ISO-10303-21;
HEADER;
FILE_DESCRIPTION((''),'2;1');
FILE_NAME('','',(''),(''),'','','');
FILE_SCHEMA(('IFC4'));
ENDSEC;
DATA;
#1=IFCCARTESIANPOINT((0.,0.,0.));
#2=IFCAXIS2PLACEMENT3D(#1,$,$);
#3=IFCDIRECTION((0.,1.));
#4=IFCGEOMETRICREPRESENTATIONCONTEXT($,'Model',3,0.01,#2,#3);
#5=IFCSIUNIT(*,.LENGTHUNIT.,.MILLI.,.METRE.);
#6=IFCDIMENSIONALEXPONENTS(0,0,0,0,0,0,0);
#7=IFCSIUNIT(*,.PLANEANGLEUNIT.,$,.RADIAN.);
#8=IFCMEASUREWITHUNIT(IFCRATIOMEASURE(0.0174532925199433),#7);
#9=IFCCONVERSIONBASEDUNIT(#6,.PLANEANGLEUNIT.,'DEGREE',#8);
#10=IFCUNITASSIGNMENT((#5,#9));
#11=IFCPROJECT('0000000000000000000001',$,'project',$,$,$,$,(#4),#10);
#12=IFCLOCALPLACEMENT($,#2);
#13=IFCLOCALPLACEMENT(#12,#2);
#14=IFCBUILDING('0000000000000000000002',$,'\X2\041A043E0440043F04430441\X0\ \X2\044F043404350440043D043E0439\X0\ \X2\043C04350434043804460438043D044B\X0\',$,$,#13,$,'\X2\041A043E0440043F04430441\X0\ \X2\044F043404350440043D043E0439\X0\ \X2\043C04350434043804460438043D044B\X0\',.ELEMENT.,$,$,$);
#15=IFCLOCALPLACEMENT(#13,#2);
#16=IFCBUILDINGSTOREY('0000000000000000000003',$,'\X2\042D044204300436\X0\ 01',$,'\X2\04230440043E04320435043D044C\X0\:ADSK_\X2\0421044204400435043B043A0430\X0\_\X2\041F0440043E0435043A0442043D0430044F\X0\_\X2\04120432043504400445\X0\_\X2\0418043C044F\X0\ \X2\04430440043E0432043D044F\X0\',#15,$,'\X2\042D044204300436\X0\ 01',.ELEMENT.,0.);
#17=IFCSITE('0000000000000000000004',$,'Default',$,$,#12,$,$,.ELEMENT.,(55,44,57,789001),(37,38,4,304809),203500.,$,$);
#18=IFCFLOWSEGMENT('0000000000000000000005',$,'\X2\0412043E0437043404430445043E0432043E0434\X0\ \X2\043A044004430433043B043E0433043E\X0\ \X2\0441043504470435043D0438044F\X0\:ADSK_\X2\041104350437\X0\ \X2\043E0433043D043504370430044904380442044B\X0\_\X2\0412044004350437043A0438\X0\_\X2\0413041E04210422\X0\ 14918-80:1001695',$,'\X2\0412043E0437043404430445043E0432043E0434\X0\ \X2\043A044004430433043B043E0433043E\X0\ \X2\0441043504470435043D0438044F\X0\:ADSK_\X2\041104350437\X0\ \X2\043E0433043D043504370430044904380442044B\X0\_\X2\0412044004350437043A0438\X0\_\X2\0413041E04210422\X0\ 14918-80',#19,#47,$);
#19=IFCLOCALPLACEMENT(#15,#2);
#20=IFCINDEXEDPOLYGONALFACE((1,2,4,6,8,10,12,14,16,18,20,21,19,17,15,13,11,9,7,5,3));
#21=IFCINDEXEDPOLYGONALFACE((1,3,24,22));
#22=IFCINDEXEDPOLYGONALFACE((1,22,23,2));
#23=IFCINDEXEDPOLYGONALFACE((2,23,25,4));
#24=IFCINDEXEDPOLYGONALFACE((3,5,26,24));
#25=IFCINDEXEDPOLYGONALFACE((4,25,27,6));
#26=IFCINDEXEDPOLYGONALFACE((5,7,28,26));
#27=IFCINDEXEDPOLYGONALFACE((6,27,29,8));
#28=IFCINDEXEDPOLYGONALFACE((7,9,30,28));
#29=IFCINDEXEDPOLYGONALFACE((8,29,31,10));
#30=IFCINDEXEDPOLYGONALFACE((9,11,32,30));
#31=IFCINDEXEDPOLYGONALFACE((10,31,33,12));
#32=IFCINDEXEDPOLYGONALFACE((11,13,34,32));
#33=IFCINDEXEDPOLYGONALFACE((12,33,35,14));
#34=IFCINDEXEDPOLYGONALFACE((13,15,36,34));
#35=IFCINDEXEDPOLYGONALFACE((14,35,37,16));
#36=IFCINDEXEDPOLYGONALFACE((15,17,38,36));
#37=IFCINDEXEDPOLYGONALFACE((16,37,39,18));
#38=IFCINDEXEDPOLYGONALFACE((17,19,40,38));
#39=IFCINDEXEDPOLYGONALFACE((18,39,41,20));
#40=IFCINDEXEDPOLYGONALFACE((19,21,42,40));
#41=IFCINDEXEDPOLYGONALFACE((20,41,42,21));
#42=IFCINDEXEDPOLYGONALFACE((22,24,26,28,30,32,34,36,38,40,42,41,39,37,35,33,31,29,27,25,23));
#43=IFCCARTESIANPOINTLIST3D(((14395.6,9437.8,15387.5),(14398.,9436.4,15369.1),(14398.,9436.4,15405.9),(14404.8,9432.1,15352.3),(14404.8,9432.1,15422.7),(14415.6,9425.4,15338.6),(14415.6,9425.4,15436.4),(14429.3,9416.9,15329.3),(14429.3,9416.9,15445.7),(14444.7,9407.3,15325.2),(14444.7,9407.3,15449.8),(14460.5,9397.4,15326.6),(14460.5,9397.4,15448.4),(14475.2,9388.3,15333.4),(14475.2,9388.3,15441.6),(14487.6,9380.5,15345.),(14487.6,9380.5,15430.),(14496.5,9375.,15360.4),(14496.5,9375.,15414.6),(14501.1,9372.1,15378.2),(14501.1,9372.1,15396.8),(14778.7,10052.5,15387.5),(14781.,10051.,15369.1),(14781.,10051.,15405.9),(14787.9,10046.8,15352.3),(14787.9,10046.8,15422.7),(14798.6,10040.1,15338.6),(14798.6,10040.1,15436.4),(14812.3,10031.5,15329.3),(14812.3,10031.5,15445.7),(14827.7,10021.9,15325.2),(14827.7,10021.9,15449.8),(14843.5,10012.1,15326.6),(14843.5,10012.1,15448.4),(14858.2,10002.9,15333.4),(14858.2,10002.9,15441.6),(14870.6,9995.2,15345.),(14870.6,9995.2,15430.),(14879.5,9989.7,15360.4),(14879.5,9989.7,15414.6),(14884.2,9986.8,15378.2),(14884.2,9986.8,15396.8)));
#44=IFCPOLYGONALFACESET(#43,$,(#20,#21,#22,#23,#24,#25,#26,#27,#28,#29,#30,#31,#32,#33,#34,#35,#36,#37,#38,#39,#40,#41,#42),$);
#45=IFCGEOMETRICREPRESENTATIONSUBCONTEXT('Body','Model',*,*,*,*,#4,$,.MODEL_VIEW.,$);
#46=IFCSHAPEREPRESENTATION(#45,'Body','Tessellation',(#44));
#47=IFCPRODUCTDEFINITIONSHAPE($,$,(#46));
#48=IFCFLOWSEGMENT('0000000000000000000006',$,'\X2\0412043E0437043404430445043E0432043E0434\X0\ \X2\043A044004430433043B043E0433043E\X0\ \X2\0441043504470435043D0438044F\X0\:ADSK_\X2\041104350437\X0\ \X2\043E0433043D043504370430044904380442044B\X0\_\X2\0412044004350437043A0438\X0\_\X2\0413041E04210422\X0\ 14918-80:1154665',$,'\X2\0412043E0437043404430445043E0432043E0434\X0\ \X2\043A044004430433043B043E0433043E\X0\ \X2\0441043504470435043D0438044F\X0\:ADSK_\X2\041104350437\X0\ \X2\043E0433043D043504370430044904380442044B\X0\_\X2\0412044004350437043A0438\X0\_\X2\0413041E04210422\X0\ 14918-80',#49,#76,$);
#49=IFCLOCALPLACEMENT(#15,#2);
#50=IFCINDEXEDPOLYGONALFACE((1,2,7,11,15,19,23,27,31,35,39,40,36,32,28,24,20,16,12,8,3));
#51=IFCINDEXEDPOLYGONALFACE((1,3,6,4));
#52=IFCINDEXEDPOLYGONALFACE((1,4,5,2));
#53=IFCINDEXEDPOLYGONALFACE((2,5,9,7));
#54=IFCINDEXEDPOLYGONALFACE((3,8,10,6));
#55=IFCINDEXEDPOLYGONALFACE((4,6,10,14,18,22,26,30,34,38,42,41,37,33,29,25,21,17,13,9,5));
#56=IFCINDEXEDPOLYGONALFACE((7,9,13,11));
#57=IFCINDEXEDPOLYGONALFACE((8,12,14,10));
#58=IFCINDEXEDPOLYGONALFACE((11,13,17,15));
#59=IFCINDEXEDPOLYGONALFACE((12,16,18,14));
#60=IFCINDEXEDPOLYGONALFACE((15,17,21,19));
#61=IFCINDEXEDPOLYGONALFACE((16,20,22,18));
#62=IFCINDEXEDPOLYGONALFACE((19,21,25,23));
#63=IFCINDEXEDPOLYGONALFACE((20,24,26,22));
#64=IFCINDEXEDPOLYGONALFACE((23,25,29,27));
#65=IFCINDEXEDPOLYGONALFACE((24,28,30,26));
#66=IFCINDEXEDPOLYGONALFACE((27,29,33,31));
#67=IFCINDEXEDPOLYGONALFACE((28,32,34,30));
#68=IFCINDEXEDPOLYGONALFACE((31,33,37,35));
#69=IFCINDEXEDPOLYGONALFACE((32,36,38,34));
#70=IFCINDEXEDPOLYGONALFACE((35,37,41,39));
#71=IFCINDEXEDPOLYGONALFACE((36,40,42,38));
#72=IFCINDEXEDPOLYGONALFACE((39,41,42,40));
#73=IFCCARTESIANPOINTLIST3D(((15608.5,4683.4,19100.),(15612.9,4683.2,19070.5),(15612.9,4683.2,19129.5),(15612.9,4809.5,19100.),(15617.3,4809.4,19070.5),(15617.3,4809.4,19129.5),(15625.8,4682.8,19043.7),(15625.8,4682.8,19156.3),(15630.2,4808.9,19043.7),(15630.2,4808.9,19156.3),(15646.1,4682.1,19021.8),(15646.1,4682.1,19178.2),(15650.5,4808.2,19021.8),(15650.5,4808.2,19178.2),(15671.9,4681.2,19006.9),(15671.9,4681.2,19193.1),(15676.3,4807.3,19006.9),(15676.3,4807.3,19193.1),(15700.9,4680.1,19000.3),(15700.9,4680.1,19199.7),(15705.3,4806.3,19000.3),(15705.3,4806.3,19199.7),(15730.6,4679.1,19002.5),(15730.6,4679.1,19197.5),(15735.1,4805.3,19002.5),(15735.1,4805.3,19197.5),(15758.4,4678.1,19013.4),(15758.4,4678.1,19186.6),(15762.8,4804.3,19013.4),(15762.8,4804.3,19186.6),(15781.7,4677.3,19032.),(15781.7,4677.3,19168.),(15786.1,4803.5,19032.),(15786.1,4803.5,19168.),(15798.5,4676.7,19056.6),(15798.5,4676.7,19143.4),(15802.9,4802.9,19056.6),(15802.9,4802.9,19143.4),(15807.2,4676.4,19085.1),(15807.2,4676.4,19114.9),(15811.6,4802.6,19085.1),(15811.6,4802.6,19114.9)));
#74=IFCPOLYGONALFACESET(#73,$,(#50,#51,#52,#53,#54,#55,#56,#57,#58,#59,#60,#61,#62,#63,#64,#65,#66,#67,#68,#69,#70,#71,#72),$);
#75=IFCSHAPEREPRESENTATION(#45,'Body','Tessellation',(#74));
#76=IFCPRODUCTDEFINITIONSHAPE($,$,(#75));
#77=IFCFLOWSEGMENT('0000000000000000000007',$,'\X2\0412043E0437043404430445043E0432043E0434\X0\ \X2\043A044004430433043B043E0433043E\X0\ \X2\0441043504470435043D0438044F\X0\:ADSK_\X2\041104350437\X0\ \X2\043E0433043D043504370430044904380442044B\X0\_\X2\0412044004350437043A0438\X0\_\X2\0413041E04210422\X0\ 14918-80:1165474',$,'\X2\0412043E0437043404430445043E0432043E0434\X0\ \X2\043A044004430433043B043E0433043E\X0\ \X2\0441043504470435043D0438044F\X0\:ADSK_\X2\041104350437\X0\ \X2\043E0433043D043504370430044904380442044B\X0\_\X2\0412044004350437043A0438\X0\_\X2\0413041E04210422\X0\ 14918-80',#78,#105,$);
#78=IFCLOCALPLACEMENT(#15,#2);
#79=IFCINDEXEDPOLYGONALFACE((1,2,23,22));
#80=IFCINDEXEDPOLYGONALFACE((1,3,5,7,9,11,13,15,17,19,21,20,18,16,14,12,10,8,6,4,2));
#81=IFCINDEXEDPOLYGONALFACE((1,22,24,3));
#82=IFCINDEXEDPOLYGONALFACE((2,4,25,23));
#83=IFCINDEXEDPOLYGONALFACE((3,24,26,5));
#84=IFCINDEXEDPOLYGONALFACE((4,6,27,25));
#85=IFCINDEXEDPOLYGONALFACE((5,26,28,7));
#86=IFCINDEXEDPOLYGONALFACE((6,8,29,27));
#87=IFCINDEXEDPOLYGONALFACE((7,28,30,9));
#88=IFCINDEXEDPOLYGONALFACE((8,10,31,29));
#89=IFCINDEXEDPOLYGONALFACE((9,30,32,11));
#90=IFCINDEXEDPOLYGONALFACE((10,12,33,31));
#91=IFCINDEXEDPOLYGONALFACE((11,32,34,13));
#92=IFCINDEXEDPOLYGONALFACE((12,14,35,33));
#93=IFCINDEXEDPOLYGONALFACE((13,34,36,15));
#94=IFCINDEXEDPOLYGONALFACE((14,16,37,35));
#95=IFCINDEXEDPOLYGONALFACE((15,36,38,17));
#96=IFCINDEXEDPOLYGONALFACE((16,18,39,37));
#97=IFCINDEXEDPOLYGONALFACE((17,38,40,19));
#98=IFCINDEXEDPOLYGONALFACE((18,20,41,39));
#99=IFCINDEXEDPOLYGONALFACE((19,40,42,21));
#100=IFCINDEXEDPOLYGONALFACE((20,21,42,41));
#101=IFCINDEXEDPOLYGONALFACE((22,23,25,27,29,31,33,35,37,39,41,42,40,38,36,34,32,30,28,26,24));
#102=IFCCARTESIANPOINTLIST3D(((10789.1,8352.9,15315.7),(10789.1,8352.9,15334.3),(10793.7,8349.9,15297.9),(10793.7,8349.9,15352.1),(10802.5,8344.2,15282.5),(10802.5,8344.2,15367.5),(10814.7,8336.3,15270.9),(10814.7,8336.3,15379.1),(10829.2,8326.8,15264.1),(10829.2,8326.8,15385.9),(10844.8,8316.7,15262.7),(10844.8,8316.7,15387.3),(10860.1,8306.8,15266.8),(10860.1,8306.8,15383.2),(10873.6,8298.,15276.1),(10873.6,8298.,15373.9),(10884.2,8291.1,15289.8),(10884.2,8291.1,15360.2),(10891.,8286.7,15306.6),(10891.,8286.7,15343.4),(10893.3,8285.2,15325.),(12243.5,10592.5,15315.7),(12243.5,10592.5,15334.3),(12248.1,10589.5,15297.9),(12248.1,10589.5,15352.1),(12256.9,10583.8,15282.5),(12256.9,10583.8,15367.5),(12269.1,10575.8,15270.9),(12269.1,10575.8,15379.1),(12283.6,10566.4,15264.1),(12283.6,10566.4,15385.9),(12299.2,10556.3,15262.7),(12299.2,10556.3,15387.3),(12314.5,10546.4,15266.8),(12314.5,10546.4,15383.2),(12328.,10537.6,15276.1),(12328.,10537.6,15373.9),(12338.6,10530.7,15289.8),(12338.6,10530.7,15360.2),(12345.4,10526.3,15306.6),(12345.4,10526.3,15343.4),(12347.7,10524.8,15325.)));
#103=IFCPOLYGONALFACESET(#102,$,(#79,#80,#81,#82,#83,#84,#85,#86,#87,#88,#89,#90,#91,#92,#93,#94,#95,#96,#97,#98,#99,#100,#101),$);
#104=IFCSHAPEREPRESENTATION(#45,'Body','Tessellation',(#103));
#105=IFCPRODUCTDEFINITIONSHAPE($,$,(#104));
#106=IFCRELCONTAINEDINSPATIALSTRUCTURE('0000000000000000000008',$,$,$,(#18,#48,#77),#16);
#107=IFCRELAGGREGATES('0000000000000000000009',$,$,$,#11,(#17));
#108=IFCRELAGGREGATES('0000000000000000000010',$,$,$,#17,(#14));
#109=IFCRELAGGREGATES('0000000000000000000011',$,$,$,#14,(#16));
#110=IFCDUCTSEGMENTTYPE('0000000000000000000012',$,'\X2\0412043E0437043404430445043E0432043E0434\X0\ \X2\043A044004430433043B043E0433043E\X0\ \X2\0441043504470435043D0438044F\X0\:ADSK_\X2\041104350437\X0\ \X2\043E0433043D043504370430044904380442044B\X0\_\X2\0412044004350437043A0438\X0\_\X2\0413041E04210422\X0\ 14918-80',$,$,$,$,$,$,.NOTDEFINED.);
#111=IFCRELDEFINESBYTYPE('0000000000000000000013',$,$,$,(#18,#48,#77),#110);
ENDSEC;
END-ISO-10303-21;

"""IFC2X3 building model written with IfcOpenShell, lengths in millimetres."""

from ifc_helpers import new_model, entity, si_unit, converted_unit, direction, frame, origin, origin_2d_with_axis, place, context, subcontext, project, spatial, circle, extrude, type_object, element, save


model = new_model("IFC2X3")

# Units and contexts
model_context = context("Model", 3, precision=0.01, world=origin(), true_north=direction((0.0, 1.0)))
body_context = subcontext(model_context, "Body", "Model", "MODEL_VIEW")
ifc_project = project(units=[si_unit("LENGTHUNIT", "METRE", prefix="MILLI"), converted_unit("PLANEANGLEUNIT", "DEGREE", entity("IfcRatioMeasure", 0.0174532925199433), si_unit("PLANEANGLEUNIT", "RADIAN"), dimensions=[0, 0, 0, 0, 0, 0, 0])], contexts=[model_context])

# Site, building, storey
site_placement = place(None, origin())
site = spatial("IfcSite", under=ifc_project, at=site_placement, Name="Default", CompositionType="ELEMENT", RefLatitude=(55, 44, 57, 789001), RefLongitude=(37, 38, 4, 304809), RefElevation=203500.0)
building_placement = place(site_placement, origin())
building = spatial("IfcBuilding", under=site, at=building_placement, Name="Корпус ядерной медицины", LongName="Корпус ядерной медицины", CompositionType="ELEMENT")
storey_placement = place(building_placement, origin())
storey = spatial("IfcBuildingStorey", under=building, at=storey_placement, Name="Этаж 01", ObjectType="Уровень:ADSK_Стрелка_Проектная_Вверх_Имя уровня", LongName="Этаж 01", CompositionType="ELEMENT", Elevation=0.0)

# Flow segments
duct_segment_type_1 = type_object("IfcDuctSegmentType", Name="Воздуховод круглого сечения:ADSK_Без огнезащиты_Врезки_ГОСТ 14918-80", PredefinedType="NOTDEFINED")
flow_segment_1_placement = place(storey_placement, frame((14394.0, 9370.1, 15323.4)))
element("IfcFlowSegment", 1, at=flow_segment_1_placement, inside=storey, type_object=duct_segment_type_1, Name="Воздуховод круглого сечения:ADSK_Без огнезащиты_Врезки_ГОСТ 14918-80:1001695", ObjectType="Воздуховод круглого сечения:ADSK_Без огнезащиты_Врезки_ГОСТ 14918-80", context=body_context, shape_type="SweptSolid", body=[
    extrude(circle(Radius=62.5, at=origin_2d_with_axis()), frame((54.6, 34.6, 64.1), z_axis=(0.528869, 0.848703, 0.0), x_axis=(-0.848703, 0.528869, 0.0)), (0.0, 0.0, 1.0), 724.3),
])
flow_segment_2_placement = place(storey_placement, frame((15606.9, 4674.8, 18998.4)))
element("IfcFlowSegment", 2, at=flow_segment_2_placement, inside=storey, type_object=duct_segment_type_1, Name="Воздуховод круглого сечения:ADSK_Без огнезащиты_Врезки_ГОСТ 14918-80:1154665", ObjectType="Воздуховод круглого сечения:ADSK_Без огнезащиты_Врезки_ГОСТ 14918-80", context=body_context, shape_type="SweptSolid", body=[
    extrude(circle(Radius=100.0, at=origin_2d_with_axis()), frame((101.5, 5.1, 101.6), z_axis=(0.034899, 0.999391, 0.0), x_axis=(-0.999391, 0.034899, 0.0)), (0.0, 0.0, 1.0), 126.2),
])
flow_segment_3_placement = place(storey_placement, frame((10786.9, 8283.6, 15260.9)))
element("IfcFlowSegment", 3, at=flow_segment_3_placement, inside=storey, type_object=duct_segment_type_1, Name="Воздуховод круглого сечения:ADSK_Без огнезащиты_Врезки_ГОСТ 14918-80:1165474", ObjectType="Воздуховод круглого сечения:ADSK_Без огнезащиты_Врезки_ГОСТ 14918-80", context=body_context, shape_type="SweptSolid", body=[
    extrude(circle(Radius=62.5, at=origin_2d_with_axis()), frame((54.0, 35.6, 64.1), z_axis=(0.544639, 0.838671, 0.0), x_axis=(0.838671, -0.544639, 0.0)), (0.0, 0.0, 1.0), 2670.4),
])

save(model, "model.ifc")
